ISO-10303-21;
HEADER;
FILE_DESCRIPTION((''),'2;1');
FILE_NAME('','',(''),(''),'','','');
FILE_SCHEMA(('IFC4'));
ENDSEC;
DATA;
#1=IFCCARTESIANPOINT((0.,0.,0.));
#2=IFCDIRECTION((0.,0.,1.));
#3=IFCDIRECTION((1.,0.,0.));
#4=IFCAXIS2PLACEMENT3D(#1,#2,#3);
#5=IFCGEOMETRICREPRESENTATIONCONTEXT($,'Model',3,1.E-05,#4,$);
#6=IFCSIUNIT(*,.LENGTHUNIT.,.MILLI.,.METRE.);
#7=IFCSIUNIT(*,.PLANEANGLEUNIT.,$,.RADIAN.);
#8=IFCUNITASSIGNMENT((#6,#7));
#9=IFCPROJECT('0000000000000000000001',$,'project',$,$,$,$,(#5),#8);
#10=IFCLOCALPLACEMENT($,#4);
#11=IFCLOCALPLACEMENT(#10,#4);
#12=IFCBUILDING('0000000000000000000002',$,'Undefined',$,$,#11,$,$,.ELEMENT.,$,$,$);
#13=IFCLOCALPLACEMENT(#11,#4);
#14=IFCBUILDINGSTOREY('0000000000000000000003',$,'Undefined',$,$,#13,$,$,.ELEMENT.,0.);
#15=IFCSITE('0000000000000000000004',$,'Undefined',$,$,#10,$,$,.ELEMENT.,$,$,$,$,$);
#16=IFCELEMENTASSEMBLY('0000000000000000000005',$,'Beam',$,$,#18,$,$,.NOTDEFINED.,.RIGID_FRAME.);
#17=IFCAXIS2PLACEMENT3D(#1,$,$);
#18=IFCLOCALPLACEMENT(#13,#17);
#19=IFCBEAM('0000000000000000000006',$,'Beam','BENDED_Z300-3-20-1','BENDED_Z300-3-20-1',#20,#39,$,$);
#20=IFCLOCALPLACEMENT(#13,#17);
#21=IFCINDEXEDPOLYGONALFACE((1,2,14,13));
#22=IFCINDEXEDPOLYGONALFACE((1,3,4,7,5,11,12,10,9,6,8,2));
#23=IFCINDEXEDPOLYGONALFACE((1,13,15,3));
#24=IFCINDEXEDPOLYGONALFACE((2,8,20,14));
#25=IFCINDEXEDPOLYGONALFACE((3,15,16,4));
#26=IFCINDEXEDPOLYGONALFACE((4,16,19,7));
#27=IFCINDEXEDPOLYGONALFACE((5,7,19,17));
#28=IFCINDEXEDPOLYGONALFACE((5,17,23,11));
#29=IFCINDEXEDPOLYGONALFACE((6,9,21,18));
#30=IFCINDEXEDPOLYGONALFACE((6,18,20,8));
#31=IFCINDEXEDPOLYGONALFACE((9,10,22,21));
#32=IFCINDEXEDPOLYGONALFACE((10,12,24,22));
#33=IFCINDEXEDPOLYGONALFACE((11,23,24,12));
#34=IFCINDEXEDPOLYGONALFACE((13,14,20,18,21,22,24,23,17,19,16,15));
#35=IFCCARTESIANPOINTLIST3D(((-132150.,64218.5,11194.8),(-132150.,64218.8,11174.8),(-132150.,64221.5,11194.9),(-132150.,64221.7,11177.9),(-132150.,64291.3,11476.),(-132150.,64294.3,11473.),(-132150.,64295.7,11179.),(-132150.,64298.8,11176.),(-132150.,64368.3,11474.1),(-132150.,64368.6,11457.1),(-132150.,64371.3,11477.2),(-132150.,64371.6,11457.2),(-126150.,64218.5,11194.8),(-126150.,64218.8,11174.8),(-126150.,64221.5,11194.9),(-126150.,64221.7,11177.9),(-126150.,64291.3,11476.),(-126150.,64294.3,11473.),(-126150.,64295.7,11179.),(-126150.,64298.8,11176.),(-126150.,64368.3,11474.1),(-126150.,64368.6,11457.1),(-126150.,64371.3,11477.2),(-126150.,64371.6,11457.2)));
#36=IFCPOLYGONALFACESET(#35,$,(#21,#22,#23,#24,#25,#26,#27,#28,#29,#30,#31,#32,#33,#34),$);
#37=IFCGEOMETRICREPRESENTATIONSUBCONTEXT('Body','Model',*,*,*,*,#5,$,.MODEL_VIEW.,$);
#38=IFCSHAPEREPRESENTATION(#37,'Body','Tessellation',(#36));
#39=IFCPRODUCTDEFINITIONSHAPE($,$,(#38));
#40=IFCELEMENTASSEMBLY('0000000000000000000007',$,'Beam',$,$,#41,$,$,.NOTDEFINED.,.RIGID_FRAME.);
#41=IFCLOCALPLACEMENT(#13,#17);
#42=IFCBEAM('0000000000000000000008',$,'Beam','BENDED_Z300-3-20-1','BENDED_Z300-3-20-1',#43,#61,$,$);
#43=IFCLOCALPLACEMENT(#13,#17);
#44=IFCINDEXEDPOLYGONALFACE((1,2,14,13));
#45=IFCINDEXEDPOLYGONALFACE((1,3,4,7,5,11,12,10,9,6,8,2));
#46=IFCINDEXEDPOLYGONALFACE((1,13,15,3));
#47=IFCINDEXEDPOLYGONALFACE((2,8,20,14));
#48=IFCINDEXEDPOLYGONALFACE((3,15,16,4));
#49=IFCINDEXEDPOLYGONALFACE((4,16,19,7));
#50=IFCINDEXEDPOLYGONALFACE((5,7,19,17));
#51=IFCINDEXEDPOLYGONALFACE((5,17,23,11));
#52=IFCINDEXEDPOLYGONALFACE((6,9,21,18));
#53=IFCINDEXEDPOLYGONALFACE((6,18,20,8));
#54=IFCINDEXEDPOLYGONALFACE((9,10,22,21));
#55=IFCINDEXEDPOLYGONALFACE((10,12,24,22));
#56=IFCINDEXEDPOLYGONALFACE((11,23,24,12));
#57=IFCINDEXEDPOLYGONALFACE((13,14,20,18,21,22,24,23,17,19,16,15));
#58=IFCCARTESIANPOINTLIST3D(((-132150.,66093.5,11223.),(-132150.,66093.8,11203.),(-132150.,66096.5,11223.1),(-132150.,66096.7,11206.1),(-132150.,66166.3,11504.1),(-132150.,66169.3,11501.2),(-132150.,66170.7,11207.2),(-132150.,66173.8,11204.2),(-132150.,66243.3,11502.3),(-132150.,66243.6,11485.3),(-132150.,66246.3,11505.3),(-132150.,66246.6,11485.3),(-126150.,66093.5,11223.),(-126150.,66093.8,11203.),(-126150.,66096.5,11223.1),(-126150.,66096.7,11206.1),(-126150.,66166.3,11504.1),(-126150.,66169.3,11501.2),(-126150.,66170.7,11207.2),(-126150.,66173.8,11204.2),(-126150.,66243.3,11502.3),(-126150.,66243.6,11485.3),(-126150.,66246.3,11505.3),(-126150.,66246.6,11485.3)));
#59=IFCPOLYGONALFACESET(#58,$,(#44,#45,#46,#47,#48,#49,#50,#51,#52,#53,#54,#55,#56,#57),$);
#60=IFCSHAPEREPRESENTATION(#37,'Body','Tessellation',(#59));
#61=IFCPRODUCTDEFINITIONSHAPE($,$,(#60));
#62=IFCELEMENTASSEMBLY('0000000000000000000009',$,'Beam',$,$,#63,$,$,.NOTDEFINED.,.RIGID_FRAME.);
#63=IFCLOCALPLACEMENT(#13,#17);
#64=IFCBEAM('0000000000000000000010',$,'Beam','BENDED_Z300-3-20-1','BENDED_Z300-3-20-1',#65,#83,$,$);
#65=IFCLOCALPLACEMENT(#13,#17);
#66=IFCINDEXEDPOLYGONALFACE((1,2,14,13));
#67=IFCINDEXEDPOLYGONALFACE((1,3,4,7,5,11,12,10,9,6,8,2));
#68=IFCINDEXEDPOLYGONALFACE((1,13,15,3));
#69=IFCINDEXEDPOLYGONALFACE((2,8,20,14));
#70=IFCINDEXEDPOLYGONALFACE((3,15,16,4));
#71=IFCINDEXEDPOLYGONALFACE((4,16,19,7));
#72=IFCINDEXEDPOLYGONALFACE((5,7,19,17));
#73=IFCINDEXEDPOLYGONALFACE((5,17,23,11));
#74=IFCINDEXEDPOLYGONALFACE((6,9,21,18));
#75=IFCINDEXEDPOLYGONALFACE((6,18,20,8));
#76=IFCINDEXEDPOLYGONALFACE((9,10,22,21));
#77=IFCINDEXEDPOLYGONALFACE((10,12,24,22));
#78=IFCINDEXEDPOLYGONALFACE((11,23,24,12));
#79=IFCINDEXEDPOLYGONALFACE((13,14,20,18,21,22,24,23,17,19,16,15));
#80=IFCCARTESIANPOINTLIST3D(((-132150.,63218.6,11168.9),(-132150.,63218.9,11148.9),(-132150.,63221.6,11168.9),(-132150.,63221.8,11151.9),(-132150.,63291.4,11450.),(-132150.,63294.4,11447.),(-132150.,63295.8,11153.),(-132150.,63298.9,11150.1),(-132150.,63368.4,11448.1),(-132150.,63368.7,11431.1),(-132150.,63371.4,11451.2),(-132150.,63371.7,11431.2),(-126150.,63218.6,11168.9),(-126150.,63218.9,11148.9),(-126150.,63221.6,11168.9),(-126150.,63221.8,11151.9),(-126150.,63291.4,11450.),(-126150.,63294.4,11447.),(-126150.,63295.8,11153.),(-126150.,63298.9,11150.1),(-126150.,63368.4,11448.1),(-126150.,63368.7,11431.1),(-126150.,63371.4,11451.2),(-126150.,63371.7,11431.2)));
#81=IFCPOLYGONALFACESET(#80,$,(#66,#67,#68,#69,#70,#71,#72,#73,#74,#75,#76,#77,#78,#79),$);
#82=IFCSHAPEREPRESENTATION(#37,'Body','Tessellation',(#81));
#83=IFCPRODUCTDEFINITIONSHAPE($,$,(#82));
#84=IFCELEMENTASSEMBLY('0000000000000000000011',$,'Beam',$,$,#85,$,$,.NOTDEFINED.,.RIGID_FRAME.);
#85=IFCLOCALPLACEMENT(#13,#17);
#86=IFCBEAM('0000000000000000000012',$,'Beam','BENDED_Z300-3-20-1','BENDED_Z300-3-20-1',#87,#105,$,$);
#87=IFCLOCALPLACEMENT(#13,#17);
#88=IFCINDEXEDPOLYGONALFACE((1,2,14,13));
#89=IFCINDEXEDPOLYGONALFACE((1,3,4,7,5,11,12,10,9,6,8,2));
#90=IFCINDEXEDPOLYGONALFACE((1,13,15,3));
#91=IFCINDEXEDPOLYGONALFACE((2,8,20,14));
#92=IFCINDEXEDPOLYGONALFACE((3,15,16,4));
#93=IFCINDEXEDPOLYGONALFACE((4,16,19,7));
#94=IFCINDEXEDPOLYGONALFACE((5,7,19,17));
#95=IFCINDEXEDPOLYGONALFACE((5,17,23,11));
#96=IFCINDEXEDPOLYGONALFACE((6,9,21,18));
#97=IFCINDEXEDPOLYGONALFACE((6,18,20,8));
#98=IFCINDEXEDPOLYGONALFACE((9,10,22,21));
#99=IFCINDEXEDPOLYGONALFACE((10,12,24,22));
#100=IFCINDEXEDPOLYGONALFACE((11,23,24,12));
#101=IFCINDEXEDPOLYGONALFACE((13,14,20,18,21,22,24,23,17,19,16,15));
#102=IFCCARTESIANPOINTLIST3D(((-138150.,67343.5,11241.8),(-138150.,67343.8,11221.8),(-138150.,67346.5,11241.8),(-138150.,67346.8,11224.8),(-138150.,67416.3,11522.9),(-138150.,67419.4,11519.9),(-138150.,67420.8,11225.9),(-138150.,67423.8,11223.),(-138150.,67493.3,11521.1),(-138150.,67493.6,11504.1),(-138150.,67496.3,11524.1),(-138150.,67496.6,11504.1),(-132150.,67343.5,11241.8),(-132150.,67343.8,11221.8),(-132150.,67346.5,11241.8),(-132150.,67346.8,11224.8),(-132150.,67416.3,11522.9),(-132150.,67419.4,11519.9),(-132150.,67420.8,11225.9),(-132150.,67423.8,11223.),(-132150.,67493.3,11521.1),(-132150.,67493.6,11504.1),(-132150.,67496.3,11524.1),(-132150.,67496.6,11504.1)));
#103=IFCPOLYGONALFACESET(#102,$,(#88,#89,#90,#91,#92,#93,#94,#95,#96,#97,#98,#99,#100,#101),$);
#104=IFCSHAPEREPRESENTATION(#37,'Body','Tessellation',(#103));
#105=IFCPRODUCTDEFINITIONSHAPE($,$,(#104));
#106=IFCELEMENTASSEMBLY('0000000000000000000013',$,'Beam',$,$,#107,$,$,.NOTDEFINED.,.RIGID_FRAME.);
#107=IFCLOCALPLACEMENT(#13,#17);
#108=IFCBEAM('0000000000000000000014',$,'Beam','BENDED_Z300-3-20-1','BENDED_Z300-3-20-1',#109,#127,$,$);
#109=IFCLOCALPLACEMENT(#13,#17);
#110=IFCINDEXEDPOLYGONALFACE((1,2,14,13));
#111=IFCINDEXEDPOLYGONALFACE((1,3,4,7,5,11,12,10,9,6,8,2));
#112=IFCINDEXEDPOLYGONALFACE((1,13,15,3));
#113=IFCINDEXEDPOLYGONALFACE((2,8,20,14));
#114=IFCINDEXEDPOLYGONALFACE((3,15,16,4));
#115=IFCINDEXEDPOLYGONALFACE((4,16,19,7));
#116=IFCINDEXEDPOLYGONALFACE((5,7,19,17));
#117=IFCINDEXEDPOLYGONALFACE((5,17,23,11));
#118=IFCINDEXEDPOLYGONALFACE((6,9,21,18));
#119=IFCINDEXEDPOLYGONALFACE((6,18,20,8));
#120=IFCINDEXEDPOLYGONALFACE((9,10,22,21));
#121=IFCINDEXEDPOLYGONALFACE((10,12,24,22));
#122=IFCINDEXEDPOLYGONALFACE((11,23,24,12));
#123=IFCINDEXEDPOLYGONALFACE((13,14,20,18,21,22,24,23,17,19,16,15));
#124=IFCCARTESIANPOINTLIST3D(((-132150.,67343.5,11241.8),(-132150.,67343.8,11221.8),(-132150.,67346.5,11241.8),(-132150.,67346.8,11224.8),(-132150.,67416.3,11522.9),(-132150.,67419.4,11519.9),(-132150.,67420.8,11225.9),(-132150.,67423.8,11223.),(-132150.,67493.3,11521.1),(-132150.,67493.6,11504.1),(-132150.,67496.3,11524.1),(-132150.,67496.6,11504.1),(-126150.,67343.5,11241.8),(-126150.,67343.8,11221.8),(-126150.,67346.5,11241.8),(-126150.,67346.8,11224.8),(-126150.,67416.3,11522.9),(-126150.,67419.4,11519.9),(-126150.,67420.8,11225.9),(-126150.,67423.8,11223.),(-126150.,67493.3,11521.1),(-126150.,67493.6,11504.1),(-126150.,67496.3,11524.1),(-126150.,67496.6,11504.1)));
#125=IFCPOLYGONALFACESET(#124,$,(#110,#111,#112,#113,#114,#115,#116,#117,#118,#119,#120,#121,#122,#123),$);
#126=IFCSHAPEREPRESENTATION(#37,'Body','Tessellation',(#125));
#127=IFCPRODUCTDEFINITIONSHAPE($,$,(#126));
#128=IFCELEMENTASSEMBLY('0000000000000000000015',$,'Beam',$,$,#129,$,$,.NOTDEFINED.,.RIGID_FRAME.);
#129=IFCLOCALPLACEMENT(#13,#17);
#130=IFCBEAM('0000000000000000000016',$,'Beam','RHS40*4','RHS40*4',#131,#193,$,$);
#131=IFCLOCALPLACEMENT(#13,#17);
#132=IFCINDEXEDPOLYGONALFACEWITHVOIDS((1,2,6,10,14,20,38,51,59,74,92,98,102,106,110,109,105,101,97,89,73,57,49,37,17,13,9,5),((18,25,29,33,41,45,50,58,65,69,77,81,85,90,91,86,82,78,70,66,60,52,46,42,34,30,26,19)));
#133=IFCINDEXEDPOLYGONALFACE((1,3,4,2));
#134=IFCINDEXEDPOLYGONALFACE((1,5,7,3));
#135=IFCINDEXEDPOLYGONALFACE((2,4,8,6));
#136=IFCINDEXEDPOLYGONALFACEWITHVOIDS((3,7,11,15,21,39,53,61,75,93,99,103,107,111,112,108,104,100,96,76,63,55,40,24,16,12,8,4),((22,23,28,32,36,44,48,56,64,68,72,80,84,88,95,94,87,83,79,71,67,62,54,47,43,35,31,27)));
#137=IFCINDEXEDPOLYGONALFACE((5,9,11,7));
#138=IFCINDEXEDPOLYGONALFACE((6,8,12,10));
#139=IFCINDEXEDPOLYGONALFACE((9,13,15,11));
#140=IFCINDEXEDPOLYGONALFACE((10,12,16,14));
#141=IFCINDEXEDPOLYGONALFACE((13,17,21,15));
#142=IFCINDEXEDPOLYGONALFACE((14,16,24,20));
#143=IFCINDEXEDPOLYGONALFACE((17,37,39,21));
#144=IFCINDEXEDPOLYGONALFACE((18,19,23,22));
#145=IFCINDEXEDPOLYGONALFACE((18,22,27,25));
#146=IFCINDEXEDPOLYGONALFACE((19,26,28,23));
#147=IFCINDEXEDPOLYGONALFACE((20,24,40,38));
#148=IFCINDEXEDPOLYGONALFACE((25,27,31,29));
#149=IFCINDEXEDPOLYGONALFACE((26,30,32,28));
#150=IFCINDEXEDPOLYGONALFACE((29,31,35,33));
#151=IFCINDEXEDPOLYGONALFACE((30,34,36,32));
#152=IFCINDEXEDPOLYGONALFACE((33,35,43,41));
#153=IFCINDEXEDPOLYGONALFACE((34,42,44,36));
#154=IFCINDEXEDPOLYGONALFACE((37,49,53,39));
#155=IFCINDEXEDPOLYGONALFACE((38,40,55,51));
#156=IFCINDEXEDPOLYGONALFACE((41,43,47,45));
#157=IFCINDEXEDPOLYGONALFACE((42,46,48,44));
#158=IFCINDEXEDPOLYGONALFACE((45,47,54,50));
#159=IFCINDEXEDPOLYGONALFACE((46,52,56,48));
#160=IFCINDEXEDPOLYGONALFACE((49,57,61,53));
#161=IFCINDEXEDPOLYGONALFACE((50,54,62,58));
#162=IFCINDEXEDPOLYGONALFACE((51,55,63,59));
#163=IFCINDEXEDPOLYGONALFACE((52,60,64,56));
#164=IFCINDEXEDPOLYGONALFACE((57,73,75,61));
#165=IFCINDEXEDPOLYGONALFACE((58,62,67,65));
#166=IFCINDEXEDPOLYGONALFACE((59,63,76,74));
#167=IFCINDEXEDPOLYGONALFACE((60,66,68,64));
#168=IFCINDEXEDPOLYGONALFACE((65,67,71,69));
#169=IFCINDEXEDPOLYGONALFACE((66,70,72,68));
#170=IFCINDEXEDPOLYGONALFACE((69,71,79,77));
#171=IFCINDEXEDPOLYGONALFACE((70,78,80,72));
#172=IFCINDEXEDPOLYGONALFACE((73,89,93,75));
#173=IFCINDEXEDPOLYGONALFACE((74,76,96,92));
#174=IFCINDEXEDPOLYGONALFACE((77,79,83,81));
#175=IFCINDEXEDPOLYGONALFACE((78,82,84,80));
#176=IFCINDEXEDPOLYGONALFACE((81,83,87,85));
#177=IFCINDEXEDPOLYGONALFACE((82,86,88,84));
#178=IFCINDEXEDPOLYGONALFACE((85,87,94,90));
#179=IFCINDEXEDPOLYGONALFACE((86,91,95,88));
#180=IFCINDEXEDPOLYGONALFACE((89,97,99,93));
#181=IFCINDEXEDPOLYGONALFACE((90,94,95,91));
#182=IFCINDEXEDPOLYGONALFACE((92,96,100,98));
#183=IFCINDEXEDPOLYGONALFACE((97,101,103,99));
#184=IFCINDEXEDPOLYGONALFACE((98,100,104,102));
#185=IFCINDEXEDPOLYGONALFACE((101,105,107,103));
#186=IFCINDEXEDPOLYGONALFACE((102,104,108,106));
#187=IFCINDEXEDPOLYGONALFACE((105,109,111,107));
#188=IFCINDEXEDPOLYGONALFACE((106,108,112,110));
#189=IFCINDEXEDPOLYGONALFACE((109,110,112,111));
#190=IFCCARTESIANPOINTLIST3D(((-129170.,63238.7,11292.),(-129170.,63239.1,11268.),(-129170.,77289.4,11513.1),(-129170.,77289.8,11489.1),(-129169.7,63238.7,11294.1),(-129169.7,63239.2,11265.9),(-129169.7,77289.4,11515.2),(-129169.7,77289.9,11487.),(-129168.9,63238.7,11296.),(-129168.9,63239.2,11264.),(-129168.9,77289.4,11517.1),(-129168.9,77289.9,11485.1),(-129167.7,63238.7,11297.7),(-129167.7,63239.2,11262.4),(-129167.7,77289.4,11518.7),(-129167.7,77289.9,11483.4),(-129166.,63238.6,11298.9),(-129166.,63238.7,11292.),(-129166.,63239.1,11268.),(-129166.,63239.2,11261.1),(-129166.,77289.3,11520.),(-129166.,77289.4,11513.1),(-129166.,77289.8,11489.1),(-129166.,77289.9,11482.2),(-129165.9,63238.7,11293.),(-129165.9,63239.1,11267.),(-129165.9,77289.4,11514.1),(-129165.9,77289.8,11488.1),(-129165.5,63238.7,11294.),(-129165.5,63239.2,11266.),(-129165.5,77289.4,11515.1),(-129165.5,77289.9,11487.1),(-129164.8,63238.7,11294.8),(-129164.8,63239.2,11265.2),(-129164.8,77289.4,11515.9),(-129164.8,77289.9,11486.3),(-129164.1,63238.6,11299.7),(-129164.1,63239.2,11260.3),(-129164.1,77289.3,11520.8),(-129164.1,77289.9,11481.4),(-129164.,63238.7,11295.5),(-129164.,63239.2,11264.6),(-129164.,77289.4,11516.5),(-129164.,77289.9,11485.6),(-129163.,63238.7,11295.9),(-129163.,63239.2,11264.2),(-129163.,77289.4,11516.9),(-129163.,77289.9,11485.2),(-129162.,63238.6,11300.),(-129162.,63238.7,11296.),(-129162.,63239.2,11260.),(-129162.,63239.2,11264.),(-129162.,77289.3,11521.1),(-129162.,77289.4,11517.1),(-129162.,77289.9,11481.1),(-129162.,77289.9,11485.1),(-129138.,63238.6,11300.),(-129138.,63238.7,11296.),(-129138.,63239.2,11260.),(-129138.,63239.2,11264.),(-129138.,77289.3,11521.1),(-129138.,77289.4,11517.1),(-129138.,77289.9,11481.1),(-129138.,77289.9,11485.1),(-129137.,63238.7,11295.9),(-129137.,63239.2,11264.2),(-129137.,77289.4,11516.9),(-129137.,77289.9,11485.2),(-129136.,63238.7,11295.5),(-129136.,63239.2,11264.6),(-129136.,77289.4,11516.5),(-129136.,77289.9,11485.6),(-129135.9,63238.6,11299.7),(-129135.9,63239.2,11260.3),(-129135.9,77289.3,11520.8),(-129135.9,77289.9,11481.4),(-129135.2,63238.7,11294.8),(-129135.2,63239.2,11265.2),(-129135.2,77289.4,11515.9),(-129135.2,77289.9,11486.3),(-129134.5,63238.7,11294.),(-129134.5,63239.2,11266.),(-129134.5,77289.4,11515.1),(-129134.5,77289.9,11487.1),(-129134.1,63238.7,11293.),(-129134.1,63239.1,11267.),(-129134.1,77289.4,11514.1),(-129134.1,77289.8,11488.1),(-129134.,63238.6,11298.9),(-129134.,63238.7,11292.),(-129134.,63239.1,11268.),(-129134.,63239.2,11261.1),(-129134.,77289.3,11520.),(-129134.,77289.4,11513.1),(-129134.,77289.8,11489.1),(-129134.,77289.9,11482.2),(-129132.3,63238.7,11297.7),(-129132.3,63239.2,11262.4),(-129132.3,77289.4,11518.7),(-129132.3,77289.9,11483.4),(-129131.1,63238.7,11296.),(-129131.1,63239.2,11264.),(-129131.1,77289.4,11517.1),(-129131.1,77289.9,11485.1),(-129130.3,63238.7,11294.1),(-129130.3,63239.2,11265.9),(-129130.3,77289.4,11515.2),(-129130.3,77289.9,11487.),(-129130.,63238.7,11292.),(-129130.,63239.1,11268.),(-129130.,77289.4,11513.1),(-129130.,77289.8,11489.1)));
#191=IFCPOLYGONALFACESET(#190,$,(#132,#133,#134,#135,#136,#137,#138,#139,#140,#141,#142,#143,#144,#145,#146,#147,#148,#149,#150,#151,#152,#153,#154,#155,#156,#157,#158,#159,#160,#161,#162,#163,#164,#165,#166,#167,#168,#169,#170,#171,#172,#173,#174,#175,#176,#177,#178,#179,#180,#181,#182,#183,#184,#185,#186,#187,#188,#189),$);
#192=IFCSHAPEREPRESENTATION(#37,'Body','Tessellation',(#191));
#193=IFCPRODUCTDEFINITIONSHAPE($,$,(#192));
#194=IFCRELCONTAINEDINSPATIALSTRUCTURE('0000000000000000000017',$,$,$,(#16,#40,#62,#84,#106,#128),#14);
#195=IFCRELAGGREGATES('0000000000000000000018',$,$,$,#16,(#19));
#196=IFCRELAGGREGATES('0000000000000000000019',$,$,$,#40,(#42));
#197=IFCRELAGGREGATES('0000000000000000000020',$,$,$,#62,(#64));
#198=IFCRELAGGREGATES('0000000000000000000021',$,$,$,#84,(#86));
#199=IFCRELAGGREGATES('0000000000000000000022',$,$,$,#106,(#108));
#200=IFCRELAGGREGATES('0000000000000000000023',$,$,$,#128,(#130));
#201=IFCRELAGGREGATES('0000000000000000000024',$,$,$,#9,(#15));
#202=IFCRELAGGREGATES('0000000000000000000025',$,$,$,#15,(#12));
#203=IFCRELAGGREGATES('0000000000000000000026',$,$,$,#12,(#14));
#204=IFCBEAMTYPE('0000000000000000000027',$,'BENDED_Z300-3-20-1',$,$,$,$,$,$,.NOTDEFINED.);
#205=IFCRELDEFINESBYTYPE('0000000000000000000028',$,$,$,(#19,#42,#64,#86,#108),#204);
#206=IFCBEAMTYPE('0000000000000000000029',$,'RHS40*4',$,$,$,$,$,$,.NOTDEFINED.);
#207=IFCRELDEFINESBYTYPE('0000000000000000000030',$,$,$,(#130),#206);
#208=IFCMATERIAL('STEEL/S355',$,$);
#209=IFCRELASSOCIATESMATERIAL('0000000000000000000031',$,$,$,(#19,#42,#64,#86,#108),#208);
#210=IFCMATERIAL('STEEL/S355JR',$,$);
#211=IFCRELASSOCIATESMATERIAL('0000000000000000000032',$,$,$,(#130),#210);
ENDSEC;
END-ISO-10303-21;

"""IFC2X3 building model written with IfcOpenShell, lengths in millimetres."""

from ifc_helpers import new_model, si_unit, frame, origin_with_axes, origin_2d_with_axis, place, context, subcontext, project, spatial, polyline, hollow_rectangle, outline, extrude, material, type_object, element, aggregate, save


model = new_model("IFC2X3")

# Units and contexts
model_context = context("Model", 3, precision=1e-05, world=origin_with_axes())
body_context = subcontext(model_context, "Body", "Model", "MODEL_VIEW")
ifc_project = project(units=[si_unit("LENGTHUNIT", "METRE", prefix="MILLI"), si_unit("PLANEANGLEUNIT", "RADIAN")], contexts=[model_context])

# Site, building, storey
site_placement = place(None, origin_with_axes())
site = spatial("IfcSite", under=ifc_project, at=site_placement, Name="Undefined", CompositionType="ELEMENT")
building_placement = place(site_placement, origin_with_axes())
building = spatial("IfcBuilding", under=site, at=building_placement, Name="Undefined", CompositionType="ELEMENT")
storey_placement = place(building_placement, origin_with_axes())
storey = spatial("IfcBuildingStorey", under=building, at=storey_placement, Name="Undefined", CompositionType="ELEMENT", Elevation=0.0)

# Element assemblies, beams
ifc_material_1 = material(Name="STEEL/S355")
beam_type_1 = type_object("IfcBeamType", Name="BENDED_Z300-3-20-1", PredefinedType="NOTDEFINED")
assembly_1_placement = place(storey_placement, origin_with_axes())
assembly_1 = element("IfcElementAssembly", 1, at=assembly_1_placement, inside=storey, Name="Beam", AssemblyPlace="NOTDEFINED", PredefinedType="RIGID_FRAME")
beam_1_placement = place(assembly_1_placement, frame((-126150.0, 64295.0, 11326.0), z_axis=(0.0, -0.014963, 0.999888), x_axis=(-1.0, 0.0, 0.0)))
beam_1 = element("IfcBeam", 2, at=beam_1_placement, type_object=beam_type_1, material=ifc_material_1, Name="Beam", Description="BENDED_Z300-3-20-1", ObjectType="BENDED_Z300-3-20-1", context=body_context, shape_type="SweptSolid", body=[
    extrude(outline(polyline([(1.5, -150.0), (-78.5, -150.0), (-78.5, -130.0), (-75.5, -130.0), (-75.5, -147.0), (-1.5, -147.0), (-1.5, 150.0), (78.5, 150.0), (78.5, 130.0), (75.5, 130.0), (75.5, 147.0), (1.5, 147.0), (1.5, -150.0)])), frame((6000.0, 0.0, 0.0), z_axis=(-1.0, 0.0, 0.0), x_axis=(0.0, -1.0, 0.0)), (0.0, 0.0, 1.0), 6000.0),
])
aggregate(assembly_1, [beam_1])
assembly_2_placement = place(storey_placement, origin_with_axes())
assembly_2 = element("IfcElementAssembly", 3, at=assembly_2_placement, inside=storey, Name="Beam", AssemblyPlace="NOTDEFINED", PredefinedType="RIGID_FRAME")
beam_2_placement = place(assembly_2_placement, frame((-126150.0, 66170.0, 11354.2), z_axis=(0.0, -0.014963, 0.999888), x_axis=(-1.0, 0.0, 0.0)))
beam_2 = element("IfcBeam", 4, at=beam_2_placement, type_object=beam_type_1, material=ifc_material_1, Name="Beam", Description="BENDED_Z300-3-20-1", ObjectType="BENDED_Z300-3-20-1", context=body_context, shape_type="SweptSolid", body=[
    extrude(outline(polyline([(1.5, -150.0), (-78.5, -150.0), (-78.5, -130.0), (-75.5, -130.0), (-75.5, -147.0), (-1.5, -147.0), (-1.5, 150.0), (78.5, 150.0), (78.5, 130.0), (75.5, 130.0), (75.5, 147.0), (1.5, 147.0), (1.5, -150.0)])), frame((6000.0, 0.0, 0.0), z_axis=(-1.0, 0.0, 0.0), x_axis=(0.0, -1.0, 0.0)), (0.0, 0.0, 1.0), 6000.0),
])
aggregate(assembly_2, [beam_2])
assembly_3_placement = place(storey_placement, origin_with_axes())
assembly_3 = element("IfcElementAssembly", 5, at=assembly_3_placement, inside=storey, Name="Beam", AssemblyPlace="NOTDEFINED", PredefinedType="RIGID_FRAME")
beam_3_placement = place(assembly_3_placement, frame((-126150.0, 63295.1, 11300.0), z_axis=(0.0, -0.014963, 0.999888), x_axis=(-1.0, 0.0, 0.0)))
beam_3 = element("IfcBeam", 6, at=beam_3_placement, type_object=beam_type_1, material=ifc_material_1, Name="Beam", Description="BENDED_Z300-3-20-1", ObjectType="BENDED_Z300-3-20-1", context=body_context, shape_type="SweptSolid", body=[
    extrude(outline(polyline([(1.5, -150.0), (-78.5, -150.0), (-78.5, -130.0), (-75.5, -130.0), (-75.5, -147.0), (-1.5, -147.0), (-1.5, 150.0), (78.5, 150.0), (78.5, 130.0), (75.5, 130.0), (75.5, 147.0), (1.5, 147.0), (1.5, -150.0)])), frame((6000.0, 0.0, 0.0), z_axis=(-1.0, 0.0, 0.0), x_axis=(0.0, -1.0, 0.0)), (0.0, 0.0, 1.0), 6000.0),
])
aggregate(assembly_3, [beam_3])
assembly_4_placement = place(storey_placement, origin_with_axes())
assembly_4 = element("IfcElementAssembly", 7, at=assembly_4_placement, inside=storey, Name="Beam", AssemblyPlace="NOTDEFINED", PredefinedType="RIGID_FRAME")
beam_4_placement = place(assembly_4_placement, frame((-132150.0, 67420.1, 11372.9), z_axis=(0.0, -0.014963, 0.999888), x_axis=(-1.0, 0.0, 0.0)))
beam_4 = element("IfcBeam", 8, at=beam_4_placement, type_object=beam_type_1, material=ifc_material_1, Name="Beam", Description="BENDED_Z300-3-20-1", ObjectType="BENDED_Z300-3-20-1", context=body_context, shape_type="SweptSolid", body=[
    extrude(outline(polyline([(1.5, -150.0), (-78.5, -150.0), (-78.5, -130.0), (-75.5, -130.0), (-75.5, -147.0), (-1.5, -147.0), (-1.5, 150.0), (78.5, 150.0), (78.5, 130.0), (75.5, 130.0), (75.5, 147.0), (1.5, 147.0), (1.5, -150.0)])), frame((6000.0, 0.0, 0.0), z_axis=(-1.0, 0.0, 0.0), x_axis=(0.0, -1.0, 0.0)), (0.0, 0.0, 1.0), 6000.0),
])
aggregate(assembly_4, [beam_4])
assembly_5_placement = place(storey_placement, origin_with_axes())
assembly_5 = element("IfcElementAssembly", 9, at=assembly_5_placement, inside=storey, Name="Beam", AssemblyPlace="NOTDEFINED", PredefinedType="RIGID_FRAME")
beam_5_placement = place(assembly_5_placement, frame((-126150.0, 67420.1, 11372.9), z_axis=(0.0, -0.014963, 0.999888), x_axis=(-1.0, 0.0, 0.0)))
beam_5 = element("IfcBeam", 10, at=beam_5_placement, type_object=beam_type_1, material=ifc_material_1, Name="Beam", Description="BENDED_Z300-3-20-1", ObjectType="BENDED_Z300-3-20-1", context=body_context, shape_type="SweptSolid", body=[
    extrude(outline(polyline([(1.5, -150.0), (-78.5, -150.0), (-78.5, -130.0), (-75.5, -130.0), (-75.5, -147.0), (-1.5, -147.0), (-1.5, 150.0), (78.5, 150.0), (78.5, 130.0), (75.5, 130.0), (75.5, 147.0), (1.5, 147.0), (1.5, -150.0)])), frame((6000.0, 0.0, 0.0), z_axis=(-1.0, 0.0, 0.0), x_axis=(0.0, -1.0, 0.0)), (0.0, 0.0, 1.0), 6000.0),
])
aggregate(assembly_5, [beam_5])
assembly_6_placement = place(storey_placement, origin_with_axes())
assembly_6 = element("IfcElementAssembly", 11, at=assembly_6_placement, inside=storey, Name="Beam", AssemblyPlace="NOTDEFINED", PredefinedType="RIGID_FRAME")
ifc_material_2 = material(Name="STEEL/S355JR")
beam_type_2 = type_object("IfcBeamType", Name="RHS40*4", PredefinedType="NOTDEFINED")
beam_6_placement = place(assembly_6_placement, frame((-129150.0, 63238.9, 11280.0), z_axis=(0.0, -0.015732, 0.999876), x_axis=(0.0, 0.999876, 0.015732)))
beam_6 = element("IfcBeam", 12, at=beam_6_placement, type_object=beam_type_2, material=ifc_material_2, Name="Beam", Description="RHS40*4", ObjectType="RHS40*4", context=body_context, shape_type="SweptSolid", body=[
    extrude(hollow_rectangle(XDim=40.0, YDim=40.0, WallThickness=4.0, InnerFilletRadius=4.0, OuterFilletRadius=8.0, at=origin_2d_with_axis()), frame((14052.4, 0.0, 0.0), z_axis=(-1.0, 0.0, 0.0), x_axis=(0.0, -1.0, 0.0)), (0.0, 0.0, 1.0), 14052.4),
])
aggregate(assembly_6, [beam_6])

save(model, "model.ifc")
